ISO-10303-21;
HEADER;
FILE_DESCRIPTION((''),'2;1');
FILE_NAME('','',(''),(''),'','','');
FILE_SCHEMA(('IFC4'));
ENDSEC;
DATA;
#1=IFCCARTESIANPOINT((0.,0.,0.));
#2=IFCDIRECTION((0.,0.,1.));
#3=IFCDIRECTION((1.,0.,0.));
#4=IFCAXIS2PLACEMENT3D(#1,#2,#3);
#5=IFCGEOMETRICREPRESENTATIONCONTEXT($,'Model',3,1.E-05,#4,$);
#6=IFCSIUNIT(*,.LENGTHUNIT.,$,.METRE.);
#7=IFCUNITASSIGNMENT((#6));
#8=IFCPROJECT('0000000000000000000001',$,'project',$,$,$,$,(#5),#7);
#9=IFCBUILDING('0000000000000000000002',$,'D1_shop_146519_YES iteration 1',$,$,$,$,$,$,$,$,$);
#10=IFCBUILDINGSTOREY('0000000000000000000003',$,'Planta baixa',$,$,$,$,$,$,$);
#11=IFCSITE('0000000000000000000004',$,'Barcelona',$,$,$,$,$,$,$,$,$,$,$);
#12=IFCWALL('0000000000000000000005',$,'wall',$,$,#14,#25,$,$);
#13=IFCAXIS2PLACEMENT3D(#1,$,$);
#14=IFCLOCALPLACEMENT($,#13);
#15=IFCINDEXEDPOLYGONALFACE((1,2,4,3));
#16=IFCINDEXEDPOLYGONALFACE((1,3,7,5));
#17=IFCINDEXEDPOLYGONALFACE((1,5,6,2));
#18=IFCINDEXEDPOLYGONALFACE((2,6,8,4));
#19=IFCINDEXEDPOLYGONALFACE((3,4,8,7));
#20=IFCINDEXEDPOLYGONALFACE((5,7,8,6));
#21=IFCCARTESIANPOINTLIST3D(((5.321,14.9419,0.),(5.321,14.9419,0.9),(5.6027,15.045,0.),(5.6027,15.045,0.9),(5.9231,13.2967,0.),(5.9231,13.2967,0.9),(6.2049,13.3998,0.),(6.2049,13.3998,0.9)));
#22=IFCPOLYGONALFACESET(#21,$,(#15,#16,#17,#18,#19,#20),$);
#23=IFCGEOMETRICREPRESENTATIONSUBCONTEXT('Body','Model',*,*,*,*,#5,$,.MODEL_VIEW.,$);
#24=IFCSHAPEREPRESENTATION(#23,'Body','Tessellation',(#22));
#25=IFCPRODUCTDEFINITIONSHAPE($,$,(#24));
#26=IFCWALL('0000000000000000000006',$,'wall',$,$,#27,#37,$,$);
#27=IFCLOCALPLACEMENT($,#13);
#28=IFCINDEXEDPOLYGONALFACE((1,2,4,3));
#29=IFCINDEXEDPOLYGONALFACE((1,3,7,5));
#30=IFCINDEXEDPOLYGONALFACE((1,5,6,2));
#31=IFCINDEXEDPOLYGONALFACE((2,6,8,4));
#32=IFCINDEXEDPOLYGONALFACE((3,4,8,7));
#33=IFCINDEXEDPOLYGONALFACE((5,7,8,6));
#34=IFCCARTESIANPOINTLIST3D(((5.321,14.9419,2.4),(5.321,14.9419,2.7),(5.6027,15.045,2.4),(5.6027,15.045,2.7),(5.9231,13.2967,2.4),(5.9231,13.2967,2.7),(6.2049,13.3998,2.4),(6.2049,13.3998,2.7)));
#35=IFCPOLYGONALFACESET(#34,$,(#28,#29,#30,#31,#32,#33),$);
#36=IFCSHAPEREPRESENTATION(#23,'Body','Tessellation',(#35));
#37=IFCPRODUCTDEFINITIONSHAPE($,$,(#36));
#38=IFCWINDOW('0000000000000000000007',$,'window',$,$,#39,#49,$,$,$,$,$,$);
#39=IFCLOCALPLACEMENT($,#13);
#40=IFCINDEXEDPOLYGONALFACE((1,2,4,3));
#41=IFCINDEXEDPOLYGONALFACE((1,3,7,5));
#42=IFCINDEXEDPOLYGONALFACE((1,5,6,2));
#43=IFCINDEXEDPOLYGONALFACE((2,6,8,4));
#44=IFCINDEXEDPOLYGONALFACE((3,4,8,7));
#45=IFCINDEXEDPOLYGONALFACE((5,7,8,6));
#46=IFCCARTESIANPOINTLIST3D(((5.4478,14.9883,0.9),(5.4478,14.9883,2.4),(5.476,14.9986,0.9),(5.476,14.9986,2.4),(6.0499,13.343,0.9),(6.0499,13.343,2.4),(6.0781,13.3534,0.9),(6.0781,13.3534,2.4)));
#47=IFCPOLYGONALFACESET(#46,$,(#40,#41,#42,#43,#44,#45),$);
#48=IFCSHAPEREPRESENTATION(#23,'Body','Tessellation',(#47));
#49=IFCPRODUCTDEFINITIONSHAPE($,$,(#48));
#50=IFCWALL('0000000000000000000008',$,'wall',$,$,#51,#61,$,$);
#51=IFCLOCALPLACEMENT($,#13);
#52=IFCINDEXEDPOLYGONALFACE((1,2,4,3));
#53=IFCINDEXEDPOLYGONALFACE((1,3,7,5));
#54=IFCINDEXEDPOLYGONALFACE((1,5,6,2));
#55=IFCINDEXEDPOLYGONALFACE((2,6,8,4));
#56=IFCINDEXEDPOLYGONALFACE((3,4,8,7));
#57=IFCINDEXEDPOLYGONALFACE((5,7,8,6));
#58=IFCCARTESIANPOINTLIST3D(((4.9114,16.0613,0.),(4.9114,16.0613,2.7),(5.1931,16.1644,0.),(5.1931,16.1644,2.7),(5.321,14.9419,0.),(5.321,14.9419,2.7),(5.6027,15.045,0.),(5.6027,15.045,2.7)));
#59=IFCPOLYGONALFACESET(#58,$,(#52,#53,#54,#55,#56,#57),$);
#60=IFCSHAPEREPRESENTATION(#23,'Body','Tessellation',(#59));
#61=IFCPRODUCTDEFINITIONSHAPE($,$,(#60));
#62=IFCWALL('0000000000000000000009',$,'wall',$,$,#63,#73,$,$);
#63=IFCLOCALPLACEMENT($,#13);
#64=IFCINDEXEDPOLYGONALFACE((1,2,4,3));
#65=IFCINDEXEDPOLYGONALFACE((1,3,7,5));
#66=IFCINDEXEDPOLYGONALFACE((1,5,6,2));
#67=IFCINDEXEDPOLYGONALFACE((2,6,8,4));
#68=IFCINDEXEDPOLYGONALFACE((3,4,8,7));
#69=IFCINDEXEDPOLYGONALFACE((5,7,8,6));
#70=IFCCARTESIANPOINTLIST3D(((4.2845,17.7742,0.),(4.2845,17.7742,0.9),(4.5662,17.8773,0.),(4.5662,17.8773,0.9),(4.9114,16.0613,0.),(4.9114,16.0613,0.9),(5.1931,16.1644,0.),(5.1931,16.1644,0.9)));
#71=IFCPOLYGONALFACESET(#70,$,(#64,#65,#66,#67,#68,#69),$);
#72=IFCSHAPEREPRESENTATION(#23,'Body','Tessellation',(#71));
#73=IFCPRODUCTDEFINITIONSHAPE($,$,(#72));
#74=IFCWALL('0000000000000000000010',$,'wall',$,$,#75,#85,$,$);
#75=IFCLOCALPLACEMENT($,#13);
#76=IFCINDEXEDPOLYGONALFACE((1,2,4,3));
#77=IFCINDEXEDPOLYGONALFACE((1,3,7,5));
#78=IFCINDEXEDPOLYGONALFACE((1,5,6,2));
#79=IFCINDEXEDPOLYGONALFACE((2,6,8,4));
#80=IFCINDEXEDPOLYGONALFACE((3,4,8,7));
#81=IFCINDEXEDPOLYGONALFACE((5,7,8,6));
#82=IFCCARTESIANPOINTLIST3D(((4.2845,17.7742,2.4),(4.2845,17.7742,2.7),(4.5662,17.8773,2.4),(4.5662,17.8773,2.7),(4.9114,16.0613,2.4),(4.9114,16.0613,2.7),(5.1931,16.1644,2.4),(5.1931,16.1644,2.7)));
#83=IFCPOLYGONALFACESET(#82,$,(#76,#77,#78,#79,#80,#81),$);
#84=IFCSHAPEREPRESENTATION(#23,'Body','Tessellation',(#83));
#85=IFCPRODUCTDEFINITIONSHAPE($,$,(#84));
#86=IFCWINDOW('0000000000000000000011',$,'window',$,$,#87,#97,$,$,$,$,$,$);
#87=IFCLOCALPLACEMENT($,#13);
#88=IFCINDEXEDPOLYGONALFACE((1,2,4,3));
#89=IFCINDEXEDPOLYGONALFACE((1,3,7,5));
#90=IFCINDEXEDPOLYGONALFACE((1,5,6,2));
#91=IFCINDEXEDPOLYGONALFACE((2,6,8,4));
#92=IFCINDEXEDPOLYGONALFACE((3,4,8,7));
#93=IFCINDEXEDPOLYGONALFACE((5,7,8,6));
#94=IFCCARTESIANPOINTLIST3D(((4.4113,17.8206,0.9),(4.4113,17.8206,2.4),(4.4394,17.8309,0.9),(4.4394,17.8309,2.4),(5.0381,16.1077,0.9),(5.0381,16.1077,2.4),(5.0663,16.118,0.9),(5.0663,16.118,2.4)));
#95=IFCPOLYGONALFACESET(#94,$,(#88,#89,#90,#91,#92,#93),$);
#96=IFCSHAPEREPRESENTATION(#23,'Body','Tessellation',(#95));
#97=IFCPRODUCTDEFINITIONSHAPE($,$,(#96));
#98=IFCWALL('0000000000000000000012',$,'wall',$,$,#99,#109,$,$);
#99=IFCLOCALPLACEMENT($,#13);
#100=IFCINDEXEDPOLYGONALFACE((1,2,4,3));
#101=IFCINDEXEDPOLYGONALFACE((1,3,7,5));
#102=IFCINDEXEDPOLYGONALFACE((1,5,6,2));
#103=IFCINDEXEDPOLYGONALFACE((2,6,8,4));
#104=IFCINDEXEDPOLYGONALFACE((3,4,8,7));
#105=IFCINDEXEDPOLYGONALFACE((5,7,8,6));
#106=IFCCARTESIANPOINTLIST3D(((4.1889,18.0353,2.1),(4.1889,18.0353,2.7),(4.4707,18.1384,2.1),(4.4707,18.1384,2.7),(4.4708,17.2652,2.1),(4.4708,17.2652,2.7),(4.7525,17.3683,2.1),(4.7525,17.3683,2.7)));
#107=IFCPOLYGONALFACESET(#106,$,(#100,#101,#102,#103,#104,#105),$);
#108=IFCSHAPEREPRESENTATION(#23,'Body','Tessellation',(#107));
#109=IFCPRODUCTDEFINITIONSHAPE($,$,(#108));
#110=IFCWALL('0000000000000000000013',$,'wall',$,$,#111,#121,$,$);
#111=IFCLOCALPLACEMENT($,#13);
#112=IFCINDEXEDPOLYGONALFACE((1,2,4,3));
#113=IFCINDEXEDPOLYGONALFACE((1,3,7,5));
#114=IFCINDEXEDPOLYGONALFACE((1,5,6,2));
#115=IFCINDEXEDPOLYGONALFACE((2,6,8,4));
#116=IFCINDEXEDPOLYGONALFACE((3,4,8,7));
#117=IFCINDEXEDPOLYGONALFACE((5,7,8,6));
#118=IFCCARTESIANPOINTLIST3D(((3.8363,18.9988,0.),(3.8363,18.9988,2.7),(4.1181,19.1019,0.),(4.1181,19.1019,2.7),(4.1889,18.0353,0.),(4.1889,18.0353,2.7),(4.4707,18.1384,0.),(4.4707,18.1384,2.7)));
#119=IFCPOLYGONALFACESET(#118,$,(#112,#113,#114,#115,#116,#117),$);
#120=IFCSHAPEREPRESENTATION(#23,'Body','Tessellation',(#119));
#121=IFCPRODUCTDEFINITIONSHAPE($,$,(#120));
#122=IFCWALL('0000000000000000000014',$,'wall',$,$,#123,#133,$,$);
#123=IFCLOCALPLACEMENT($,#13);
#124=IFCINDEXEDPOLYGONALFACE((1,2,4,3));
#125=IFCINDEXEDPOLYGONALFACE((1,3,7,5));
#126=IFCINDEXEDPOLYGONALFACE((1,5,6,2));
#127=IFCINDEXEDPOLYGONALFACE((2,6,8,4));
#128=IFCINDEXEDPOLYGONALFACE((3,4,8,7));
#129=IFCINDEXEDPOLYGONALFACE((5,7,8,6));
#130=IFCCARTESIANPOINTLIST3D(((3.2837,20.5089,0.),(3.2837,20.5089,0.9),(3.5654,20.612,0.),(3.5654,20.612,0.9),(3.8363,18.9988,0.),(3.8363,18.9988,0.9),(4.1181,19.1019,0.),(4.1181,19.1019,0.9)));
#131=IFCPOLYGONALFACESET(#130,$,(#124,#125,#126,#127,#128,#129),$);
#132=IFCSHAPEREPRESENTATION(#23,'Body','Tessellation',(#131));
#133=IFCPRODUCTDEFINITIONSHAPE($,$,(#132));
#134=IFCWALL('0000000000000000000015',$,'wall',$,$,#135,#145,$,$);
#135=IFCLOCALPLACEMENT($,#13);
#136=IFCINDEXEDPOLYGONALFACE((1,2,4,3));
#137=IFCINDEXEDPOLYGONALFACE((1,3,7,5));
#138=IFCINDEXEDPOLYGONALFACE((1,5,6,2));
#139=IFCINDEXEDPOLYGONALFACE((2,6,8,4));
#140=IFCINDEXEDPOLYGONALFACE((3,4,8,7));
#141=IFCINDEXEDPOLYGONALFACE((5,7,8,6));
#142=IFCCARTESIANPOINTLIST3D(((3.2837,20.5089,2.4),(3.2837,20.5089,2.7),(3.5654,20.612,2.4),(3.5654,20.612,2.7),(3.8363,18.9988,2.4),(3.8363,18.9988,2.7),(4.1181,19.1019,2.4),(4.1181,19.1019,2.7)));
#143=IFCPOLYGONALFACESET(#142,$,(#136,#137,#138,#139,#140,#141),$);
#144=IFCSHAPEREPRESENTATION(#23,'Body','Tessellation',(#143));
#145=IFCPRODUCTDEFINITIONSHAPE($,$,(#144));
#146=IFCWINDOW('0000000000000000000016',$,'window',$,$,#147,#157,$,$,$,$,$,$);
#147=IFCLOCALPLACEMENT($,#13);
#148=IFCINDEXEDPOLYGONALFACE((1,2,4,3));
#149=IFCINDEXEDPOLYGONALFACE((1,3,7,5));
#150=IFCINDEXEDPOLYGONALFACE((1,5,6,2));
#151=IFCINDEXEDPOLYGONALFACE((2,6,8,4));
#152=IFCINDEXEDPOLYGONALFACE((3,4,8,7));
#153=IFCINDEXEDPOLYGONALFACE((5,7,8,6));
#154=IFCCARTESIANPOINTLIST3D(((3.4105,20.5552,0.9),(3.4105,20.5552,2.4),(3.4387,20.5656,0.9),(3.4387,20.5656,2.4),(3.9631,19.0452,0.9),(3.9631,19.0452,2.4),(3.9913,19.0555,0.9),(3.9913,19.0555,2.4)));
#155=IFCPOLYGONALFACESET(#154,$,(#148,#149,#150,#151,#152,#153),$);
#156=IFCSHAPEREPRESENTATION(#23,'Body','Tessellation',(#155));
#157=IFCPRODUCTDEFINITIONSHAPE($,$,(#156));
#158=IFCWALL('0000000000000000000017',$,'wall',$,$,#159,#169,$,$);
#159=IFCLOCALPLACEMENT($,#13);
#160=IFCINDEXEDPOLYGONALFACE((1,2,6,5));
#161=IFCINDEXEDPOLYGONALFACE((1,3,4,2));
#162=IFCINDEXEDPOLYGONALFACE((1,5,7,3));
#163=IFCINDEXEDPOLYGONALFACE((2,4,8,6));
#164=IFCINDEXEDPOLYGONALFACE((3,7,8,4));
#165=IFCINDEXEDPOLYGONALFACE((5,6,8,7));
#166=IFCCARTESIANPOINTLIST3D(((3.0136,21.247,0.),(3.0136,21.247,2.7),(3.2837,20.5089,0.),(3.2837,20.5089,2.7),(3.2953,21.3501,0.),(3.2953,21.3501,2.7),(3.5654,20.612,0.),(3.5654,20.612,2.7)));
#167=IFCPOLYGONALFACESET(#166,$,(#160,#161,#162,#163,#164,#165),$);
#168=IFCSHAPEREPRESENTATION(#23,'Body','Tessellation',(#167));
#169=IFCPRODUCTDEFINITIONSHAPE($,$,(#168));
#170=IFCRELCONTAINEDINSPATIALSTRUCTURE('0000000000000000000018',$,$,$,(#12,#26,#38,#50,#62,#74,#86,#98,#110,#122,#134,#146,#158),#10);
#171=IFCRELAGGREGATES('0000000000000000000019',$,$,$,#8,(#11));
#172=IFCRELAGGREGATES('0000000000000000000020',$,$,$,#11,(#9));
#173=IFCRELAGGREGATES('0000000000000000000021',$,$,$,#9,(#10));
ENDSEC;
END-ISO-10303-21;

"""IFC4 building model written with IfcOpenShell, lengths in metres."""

from ifc_helpers import new_model, si_unit, frame, origin, origin_with_axes, place, context, subcontext, project, spatial, polyline, outline, extrude, element, save


model = new_model("IFC4")

# Units and contexts
model_context = context("Model", 3, precision=1e-05, world=origin_with_axes())
body_context = subcontext(model_context, "Body", "Model", "MODEL_VIEW")
ifc_project = project(units=[si_unit("LENGTHUNIT", "METRE")], contexts=[model_context])

# Site, building, storey
site = spatial("IfcSite", under=ifc_project, Name="Barcelona")
building = spatial("IfcBuilding", under=site, Name="D1_shop_146519_YES iteration 1")
storey = spatial("IfcBuildingStorey", under=building, Name="Planta baixa")

# Walls
wall_1_placement = place(None, origin_with_axes())
element("IfcWall", 1, at=wall_1_placement, inside=storey, Name="wall", context=body_context, shape_type="SweptSolid", body=[
    extrude(outline(polyline([(5.9231, 13.2967), (5.321, 14.9419), (5.6027, 15.045), (6.2049, 13.3998), (5.9231, 13.2967)])), origin(), (0.0, 0.0, 1.0), 0.9),
])
wall_2_placement = place(None, origin_with_axes())
element("IfcWall", 2, at=wall_2_placement, inside=storey, Name="wall", context=body_context, shape_type="SweptSolid", body=[
    extrude(outline(polyline([(5.9231, 13.2967), (5.321, 14.9419), (5.6027, 15.045), (6.2049, 13.3998), (5.9231, 13.2967)])), frame((0.0, 0.0, 2.4)), (0.0, 0.0, 1.0), 0.3),
])

# Window
window_1_placement = place(None, origin_with_axes())
element("IfcWindow", 3, at=window_1_placement, inside=storey, Name="window", context=body_context, shape_type="SweptSolid", body=[
    extrude(outline(polyline([(6.0499, 13.343), (5.4478, 14.9883), (5.476, 14.9986), (6.0781, 13.3534), (6.0499, 13.343)])), frame((0.0, 0.0, 0.9)), (0.0, 0.0, 1.0), 1.5),
])

# Walls
wall_3_placement = place(None, origin_with_axes())
element("IfcWall", 4, at=wall_3_placement, inside=storey, Name="wall", context=body_context, shape_type="SweptSolid", body=[
    extrude(outline(polyline([(5.321, 14.9419), (4.9114, 16.0613), (5.1931, 16.1644), (5.6027, 15.045), (5.321, 14.9419)])), origin(), (0.0, 0.0, 1.0), 2.7),
])
wall_4_placement = place(None, origin_with_axes())
element("IfcWall", 5, at=wall_4_placement, inside=storey, Name="wall", context=body_context, shape_type="SweptSolid", body=[
    extrude(outline(polyline([(4.9114, 16.0613), (4.2845, 17.7742), (4.5662, 17.8773), (5.1931, 16.1644), (4.9114, 16.0613)])), origin(), (0.0, 0.0, 1.0), 0.9),
])
wall_5_placement = place(None, origin_with_axes())
element("IfcWall", 6, at=wall_5_placement, inside=storey, Name="wall", context=body_context, shape_type="SweptSolid", body=[
    extrude(outline(polyline([(4.9114, 16.0613), (4.2845, 17.7742), (4.5662, 17.8773), (5.1931, 16.1644), (4.9114, 16.0613)])), frame((0.0, 0.0, 2.4)), (0.0, 0.0, 1.0), 0.3),
])

# Window
window_2_placement = place(None, origin_with_axes())
element("IfcWindow", 7, at=window_2_placement, inside=storey, Name="window", context=body_context, shape_type="SweptSolid", body=[
    extrude(outline(polyline([(5.0381, 16.1077), (4.4113, 17.8206), (4.4394, 17.8309), (5.0663, 16.118), (5.0381, 16.1077)])), frame((0.0, 0.0, 0.9)), (0.0, 0.0, 1.0), 1.5),
])

# Walls
wall_6_placement = place(None, origin_with_axes())
element("IfcWall", 8, at=wall_6_placement, inside=storey, Name="wall", context=body_context, shape_type="SweptSolid", body=[
    extrude(outline(polyline([(4.4708, 17.2652), (4.1889, 18.0353), (4.4707, 18.1384), (4.7525, 17.3683), (4.4708, 17.2652)])), frame((0.0, 0.0, 2.1)), (0.0, 0.0, 1.0), 0.6),
])
wall_7_placement = place(None, origin_with_axes())
element("IfcWall", 9, at=wall_7_placement, inside=storey, Name="wall", context=body_context, shape_type="SweptSolid", body=[
    extrude(outline(polyline([(4.1889, 18.0353), (3.8363, 18.9988), (4.1181, 19.1019), (4.4707, 18.1384), (4.1889, 18.0353)])), origin(), (0.0, 0.0, 1.0), 2.7),
])
wall_8_placement = place(None, origin_with_axes())
element("IfcWall", 10, at=wall_8_placement, inside=storey, Name="wall", context=body_context, shape_type="SweptSolid", body=[
    extrude(outline(polyline([(3.8363, 18.9988), (3.2837, 20.5089), (3.5654, 20.612), (4.1181, 19.1019), (3.8363, 18.9988)])), origin(), (0.0, 0.0, 1.0), 0.9),
])
wall_9_placement = place(None, origin_with_axes())
element("IfcWall", 11, at=wall_9_placement, inside=storey, Name="wall", context=body_context, shape_type="SweptSolid", body=[
    extrude(outline(polyline([(3.8363, 18.9988), (3.2837, 20.5089), (3.5654, 20.612), (4.1181, 19.1019), (3.8363, 18.9988)])), frame((0.0, 0.0, 2.4)), (0.0, 0.0, 1.0), 0.3),
])

# Window
window_3_placement = place(None, origin_with_axes())
element("IfcWindow", 12, at=window_3_placement, inside=storey, Name="window", context=body_context, shape_type="SweptSolid", body=[
    extrude(outline(polyline([(3.9631, 19.0452), (3.4105, 20.5552), (3.4387, 20.5656), (3.9913, 19.0555), (3.9631, 19.0452)])), frame((0.0, 0.0, 0.9)), (0.0, 0.0, 1.0), 1.5),
])

# Wall
wall_10_placement = place(None, origin_with_axes())
element("IfcWall", 13, at=wall_10_placement, inside=storey, Name="wall", context=body_context, shape_type="SweptSolid", body=[
    extrude(outline(polyline([(3.2837, 20.5089), (3.0136, 21.247), (3.2953, 21.3501), (3.5654, 20.612), (3.2837, 20.5089)])), origin(), (0.0, 0.0, 1.0), 2.7),
])

save(model, "model.ifc")
